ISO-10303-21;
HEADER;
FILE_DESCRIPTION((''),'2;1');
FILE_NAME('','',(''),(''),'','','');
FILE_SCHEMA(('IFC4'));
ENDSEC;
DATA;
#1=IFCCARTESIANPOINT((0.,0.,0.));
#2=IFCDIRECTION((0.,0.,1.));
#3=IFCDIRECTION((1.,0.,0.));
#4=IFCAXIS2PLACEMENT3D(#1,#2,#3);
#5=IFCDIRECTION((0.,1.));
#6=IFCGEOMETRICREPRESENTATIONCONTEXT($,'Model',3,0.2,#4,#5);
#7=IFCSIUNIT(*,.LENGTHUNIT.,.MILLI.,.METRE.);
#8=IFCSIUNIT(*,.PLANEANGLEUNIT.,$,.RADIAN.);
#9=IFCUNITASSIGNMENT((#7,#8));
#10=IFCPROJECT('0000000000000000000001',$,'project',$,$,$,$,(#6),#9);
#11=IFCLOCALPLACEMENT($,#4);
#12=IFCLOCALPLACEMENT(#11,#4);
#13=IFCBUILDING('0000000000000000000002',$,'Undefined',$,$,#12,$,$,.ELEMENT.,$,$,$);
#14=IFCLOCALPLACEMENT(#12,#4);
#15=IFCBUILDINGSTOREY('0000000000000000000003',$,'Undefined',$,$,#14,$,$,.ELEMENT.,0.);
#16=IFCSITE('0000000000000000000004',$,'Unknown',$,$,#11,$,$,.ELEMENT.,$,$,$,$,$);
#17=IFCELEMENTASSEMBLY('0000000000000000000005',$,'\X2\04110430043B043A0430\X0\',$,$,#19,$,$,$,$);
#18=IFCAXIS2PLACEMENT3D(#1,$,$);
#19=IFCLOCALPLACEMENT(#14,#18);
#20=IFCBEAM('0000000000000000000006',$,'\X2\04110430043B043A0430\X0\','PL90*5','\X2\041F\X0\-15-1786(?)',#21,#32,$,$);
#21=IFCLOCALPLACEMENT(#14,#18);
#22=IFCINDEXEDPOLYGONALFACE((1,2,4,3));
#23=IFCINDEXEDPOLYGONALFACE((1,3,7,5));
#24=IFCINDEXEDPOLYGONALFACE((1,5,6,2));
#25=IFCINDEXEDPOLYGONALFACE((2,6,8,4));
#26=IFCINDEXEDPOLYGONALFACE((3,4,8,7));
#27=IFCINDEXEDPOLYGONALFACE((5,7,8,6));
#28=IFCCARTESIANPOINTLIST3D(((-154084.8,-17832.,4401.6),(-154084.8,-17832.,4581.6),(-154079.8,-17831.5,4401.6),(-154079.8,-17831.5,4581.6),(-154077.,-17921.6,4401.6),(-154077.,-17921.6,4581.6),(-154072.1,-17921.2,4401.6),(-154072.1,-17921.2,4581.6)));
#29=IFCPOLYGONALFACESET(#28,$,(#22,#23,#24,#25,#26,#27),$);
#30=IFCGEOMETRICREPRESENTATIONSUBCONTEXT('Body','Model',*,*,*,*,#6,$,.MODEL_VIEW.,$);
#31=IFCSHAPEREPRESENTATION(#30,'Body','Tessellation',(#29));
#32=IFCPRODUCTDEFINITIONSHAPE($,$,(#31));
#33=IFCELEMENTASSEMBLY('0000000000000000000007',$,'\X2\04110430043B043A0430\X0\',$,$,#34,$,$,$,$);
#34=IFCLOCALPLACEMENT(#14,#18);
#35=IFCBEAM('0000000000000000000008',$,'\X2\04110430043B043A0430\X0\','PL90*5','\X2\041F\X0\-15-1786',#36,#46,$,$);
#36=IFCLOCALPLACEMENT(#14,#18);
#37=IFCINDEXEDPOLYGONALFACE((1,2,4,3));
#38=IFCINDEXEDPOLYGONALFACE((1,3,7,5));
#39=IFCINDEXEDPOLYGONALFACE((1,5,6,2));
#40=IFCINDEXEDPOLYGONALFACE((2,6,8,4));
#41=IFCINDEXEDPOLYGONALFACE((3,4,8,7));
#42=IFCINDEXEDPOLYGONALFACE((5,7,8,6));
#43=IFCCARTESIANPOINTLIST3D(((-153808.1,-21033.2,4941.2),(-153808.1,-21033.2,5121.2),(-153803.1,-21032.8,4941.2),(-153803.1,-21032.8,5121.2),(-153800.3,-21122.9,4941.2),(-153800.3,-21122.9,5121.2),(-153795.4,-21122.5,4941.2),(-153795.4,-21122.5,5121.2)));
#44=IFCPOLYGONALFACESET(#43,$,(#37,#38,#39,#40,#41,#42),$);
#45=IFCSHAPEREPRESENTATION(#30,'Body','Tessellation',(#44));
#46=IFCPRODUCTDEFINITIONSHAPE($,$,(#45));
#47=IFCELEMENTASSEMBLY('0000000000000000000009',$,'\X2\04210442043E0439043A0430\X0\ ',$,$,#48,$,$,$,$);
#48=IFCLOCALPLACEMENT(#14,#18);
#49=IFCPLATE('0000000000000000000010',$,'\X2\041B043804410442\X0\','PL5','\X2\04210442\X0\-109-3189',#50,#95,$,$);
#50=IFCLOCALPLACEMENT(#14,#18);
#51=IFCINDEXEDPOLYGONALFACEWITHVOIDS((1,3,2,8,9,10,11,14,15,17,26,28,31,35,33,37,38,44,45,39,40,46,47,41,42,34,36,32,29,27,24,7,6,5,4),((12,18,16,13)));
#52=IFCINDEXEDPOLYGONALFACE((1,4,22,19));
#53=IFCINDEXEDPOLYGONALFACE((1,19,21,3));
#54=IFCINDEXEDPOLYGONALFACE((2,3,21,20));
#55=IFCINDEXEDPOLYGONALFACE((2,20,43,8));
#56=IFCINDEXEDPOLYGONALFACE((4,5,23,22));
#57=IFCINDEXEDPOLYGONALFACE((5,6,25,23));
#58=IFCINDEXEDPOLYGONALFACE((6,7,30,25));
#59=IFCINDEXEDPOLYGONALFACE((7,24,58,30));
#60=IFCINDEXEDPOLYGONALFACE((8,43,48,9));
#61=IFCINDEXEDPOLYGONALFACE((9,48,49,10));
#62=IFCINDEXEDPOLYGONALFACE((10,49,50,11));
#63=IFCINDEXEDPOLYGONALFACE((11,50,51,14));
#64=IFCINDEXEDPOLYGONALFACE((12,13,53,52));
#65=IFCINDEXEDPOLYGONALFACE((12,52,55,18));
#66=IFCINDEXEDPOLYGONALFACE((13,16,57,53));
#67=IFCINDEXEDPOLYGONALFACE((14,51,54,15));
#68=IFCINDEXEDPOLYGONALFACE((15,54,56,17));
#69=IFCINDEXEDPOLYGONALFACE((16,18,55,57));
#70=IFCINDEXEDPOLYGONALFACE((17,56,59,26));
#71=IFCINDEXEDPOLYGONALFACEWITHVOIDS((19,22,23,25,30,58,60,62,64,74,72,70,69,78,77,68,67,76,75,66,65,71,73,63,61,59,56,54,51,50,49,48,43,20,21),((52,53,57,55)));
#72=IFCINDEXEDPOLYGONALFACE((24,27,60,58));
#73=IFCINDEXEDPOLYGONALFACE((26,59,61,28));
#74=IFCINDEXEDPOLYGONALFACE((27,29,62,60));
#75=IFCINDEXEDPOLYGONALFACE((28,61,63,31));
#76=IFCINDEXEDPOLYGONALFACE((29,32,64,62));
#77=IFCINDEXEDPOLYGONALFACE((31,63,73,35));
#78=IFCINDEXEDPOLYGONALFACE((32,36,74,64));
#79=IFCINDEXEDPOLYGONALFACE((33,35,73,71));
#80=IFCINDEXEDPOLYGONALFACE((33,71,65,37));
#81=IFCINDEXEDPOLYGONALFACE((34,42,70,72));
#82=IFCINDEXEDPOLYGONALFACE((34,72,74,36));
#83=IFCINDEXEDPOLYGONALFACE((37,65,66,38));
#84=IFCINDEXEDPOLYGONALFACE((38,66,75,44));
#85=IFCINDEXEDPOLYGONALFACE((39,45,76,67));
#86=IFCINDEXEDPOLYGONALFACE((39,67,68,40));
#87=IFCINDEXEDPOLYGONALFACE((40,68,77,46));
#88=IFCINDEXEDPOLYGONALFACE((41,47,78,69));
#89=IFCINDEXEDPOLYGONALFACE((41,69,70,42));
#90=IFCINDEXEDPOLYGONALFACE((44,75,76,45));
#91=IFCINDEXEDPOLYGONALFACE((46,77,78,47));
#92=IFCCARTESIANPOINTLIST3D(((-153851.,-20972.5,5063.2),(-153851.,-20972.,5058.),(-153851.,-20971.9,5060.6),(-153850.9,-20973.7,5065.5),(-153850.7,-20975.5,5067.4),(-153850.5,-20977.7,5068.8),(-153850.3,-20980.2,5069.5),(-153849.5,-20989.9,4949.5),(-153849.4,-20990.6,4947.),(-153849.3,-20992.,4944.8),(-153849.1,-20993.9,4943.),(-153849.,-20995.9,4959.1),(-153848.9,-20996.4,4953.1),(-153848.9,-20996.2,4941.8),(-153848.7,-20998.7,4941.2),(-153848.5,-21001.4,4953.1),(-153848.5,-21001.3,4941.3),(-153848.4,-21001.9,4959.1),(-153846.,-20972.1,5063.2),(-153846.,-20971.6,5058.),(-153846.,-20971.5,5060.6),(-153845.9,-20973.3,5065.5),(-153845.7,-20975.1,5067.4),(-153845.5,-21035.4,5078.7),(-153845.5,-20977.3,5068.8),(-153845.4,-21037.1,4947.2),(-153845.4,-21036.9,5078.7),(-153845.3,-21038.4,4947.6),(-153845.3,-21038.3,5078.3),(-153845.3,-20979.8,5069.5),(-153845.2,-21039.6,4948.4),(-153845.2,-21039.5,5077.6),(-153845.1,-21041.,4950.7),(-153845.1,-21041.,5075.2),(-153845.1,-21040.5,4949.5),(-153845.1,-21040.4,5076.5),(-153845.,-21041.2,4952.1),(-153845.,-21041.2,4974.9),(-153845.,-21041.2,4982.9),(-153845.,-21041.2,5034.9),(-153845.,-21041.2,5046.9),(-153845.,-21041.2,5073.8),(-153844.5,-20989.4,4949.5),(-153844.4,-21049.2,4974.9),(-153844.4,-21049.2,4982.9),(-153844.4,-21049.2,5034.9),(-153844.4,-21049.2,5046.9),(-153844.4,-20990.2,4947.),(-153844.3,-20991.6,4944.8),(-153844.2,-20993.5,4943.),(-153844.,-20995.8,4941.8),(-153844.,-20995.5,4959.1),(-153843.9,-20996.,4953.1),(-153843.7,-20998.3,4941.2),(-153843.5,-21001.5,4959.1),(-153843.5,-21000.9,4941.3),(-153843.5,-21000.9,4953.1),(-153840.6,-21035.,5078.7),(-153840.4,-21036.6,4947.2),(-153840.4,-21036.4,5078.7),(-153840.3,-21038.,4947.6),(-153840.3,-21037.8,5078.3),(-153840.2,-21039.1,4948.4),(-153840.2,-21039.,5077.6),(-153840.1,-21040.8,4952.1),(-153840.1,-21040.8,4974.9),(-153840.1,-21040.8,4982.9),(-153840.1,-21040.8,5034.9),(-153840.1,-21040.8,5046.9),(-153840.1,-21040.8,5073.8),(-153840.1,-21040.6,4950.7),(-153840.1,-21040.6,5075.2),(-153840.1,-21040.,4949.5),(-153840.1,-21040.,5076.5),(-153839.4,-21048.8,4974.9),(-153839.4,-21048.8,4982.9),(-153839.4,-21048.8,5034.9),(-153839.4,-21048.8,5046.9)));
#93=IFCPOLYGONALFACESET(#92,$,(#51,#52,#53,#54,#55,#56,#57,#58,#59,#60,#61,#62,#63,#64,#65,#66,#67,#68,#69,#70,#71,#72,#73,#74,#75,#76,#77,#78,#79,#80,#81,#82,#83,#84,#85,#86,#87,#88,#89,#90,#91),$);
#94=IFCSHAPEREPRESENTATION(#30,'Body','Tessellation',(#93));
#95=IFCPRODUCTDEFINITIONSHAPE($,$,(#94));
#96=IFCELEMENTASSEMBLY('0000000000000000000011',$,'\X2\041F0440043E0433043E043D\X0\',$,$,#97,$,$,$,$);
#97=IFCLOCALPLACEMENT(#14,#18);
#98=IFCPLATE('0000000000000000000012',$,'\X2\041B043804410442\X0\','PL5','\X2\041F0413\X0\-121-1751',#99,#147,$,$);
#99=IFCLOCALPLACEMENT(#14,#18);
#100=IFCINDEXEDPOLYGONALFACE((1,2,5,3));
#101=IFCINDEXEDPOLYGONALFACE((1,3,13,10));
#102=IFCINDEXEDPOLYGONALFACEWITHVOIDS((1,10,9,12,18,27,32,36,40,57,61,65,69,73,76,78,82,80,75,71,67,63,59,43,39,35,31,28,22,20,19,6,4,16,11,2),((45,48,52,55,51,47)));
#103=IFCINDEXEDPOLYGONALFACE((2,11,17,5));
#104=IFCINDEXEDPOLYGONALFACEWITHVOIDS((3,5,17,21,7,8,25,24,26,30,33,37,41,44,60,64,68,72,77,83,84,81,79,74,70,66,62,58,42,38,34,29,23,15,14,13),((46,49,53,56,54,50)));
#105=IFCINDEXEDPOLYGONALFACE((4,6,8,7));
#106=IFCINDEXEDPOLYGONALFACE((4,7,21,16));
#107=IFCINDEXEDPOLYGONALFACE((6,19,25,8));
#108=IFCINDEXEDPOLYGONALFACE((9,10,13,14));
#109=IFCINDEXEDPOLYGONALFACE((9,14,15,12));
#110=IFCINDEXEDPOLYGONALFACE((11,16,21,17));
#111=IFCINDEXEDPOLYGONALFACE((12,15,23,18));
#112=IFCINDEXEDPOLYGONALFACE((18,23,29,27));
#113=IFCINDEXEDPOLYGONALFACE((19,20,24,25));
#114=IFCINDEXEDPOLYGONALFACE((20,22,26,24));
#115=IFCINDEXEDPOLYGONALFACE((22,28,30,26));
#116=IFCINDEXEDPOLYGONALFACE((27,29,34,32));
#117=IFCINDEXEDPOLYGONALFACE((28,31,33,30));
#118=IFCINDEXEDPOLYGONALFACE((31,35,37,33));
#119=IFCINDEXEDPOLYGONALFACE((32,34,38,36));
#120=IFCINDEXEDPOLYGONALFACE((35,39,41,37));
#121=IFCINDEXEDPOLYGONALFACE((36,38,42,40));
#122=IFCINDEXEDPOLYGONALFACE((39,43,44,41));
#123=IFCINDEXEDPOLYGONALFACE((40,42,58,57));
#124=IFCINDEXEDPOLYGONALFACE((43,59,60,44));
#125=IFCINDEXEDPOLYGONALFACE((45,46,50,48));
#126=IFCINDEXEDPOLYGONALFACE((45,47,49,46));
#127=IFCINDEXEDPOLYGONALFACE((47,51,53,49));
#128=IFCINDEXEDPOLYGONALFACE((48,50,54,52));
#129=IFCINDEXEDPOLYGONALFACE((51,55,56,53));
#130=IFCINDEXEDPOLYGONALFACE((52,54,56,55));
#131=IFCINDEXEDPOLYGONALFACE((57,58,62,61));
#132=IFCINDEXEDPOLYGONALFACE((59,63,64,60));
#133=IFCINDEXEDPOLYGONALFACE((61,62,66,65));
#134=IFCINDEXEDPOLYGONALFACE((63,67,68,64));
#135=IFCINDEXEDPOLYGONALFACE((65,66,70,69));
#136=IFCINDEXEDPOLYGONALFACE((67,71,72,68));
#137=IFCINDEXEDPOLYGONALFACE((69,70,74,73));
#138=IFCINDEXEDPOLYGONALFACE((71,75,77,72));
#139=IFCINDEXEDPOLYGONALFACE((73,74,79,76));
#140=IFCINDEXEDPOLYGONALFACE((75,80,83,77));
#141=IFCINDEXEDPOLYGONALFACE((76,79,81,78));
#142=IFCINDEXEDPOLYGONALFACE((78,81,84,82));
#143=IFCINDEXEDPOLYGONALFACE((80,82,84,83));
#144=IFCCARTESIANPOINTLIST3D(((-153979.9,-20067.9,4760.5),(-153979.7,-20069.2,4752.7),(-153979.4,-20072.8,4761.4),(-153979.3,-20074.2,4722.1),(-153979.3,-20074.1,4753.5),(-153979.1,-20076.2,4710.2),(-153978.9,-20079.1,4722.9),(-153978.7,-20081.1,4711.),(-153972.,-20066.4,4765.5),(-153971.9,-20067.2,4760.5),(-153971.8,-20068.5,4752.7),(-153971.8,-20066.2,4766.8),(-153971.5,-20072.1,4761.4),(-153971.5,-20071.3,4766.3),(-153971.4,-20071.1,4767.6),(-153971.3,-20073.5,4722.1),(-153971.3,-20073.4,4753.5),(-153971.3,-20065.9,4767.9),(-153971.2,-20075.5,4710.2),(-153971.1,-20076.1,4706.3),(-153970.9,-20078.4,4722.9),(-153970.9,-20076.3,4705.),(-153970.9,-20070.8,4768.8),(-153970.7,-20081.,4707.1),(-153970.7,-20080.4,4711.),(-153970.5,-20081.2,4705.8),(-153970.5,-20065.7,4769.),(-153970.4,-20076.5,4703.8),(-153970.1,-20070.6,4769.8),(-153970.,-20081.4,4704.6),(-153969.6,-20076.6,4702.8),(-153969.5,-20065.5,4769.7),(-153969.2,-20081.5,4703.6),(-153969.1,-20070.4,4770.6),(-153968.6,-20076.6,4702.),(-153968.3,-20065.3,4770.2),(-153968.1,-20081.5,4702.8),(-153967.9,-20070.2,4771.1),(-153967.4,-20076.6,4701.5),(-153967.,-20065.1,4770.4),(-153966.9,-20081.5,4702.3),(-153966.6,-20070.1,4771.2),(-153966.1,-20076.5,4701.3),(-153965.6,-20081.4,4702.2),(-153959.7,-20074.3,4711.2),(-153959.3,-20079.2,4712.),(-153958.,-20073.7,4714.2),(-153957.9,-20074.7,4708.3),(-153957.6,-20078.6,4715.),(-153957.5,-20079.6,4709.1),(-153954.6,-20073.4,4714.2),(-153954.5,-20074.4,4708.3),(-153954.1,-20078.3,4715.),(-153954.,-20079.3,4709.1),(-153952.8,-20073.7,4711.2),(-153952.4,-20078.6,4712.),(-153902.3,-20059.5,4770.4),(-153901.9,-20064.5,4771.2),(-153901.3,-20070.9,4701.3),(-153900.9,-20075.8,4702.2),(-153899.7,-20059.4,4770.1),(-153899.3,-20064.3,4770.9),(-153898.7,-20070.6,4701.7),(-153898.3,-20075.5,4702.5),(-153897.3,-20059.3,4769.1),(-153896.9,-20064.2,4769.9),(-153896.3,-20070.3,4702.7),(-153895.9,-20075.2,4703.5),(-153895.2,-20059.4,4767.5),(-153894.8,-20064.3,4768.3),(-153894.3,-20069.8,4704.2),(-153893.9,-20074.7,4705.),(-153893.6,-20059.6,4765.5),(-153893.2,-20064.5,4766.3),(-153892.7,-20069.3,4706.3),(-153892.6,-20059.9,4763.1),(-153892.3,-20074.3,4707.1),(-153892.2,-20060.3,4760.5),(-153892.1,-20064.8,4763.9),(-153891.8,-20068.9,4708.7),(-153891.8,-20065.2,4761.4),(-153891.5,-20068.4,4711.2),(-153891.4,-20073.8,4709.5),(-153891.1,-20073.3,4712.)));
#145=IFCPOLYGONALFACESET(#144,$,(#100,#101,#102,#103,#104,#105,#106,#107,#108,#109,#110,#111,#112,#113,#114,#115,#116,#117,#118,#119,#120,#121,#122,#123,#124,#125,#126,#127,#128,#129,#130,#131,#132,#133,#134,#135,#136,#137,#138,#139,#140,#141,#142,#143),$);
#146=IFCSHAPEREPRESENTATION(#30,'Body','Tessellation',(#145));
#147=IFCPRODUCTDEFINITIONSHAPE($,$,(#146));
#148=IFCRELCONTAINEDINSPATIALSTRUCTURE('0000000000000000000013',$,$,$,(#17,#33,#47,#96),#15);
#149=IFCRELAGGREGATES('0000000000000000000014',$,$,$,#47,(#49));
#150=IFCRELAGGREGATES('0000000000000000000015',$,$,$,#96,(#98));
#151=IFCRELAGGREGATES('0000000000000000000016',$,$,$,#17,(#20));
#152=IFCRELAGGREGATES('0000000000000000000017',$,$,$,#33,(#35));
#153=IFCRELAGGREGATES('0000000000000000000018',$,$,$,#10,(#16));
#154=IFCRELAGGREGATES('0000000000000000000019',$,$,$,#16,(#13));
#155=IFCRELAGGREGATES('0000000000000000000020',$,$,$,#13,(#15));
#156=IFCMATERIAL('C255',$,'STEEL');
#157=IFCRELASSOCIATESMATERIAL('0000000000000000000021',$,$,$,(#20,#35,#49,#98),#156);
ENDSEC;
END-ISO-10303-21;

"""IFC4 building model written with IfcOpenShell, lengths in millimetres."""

from ifc_helpers import new_model, si_unit, direction, frame, origin_with_axes, place, context, subcontext, project, spatial, line, arc, indexed_curve, outline, extrude, material, element, aggregate, save


model = new_model("IFC4")

# Units and contexts
model_context = context("Model", 3, precision=0.2, world=origin_with_axes(), true_north=direction((0.0, 1.0)))
body_context = subcontext(model_context, "Body", "Model", "MODEL_VIEW")
ifc_project = project(units=[si_unit("LENGTHUNIT", "METRE", prefix="MILLI"), si_unit("PLANEANGLEUNIT", "RADIAN")], contexts=[model_context])

# Site, building, storey
site_placement = place(None, origin_with_axes())
site = spatial("IfcSite", under=ifc_project, at=site_placement, Name="Unknown", CompositionType="ELEMENT")
building_placement = place(site_placement, origin_with_axes())
building = spatial("IfcBuilding", under=site, at=building_placement, Name="Undefined", CompositionType="ELEMENT")
storey_placement = place(building_placement, origin_with_axes())
storey = spatial("IfcBuildingStorey", under=building, at=storey_placement, Name="Undefined", CompositionType="ELEMENT", Elevation=0.0)

# Element assemblies, beams
assembly_1_placement = place(storey_placement, frame((-154078.4, -17876.6, 4581.6), z_axis=(0.996285, 0.086114, 0.0), x_axis=(0.0, 0.0, -1.0)))
assembly_1 = element("IfcElementAssembly", 1, at=assembly_1_placement, inside=storey, Name="Балка")
ifc_material_1 = material(Name="C255", Category="STEEL")
beam_1_placement = place(assembly_1_placement, origin_with_axes())
beam_1 = element("IfcBeam", 2, at=beam_1_placement, material=ifc_material_1, Name="Балка", Description="PL90*5", ObjectType="П-15-1786(?)", context=body_context, shape_type="SolidModel", body=[
    extrude(outline(indexed_curve([(-2.5, -45.0), (2.5, -45.0), (2.5, 45.0), (-2.5, 45.0)], segments=[line(1, 2, 3, 4, 1)])), frame((0.0, 0.0, 0.0), z_axis=(-1.0, 0.0, 0.0), x_axis=(0.0, 0.0, 1.0)), (0.0, 0.0, -1.0), 180.0),
])
assembly_2_placement = place(storey_placement, frame((-153801.7, -21077.8, 5121.2), z_axis=(0.996285, 0.086114, 0.0), x_axis=(0.0, 0.0, -1.0)))
assembly_2 = element("IfcElementAssembly", 3, at=assembly_2_placement, inside=storey, Name="Балка")
beam_2_placement = place(assembly_2_placement, origin_with_axes())
beam_2 = element("IfcBeam", 4, at=beam_2_placement, material=ifc_material_1, Name="Балка", Description="PL90*5", ObjectType="П-15-1786", context=body_context, shape_type="SolidModel", body=[
    extrude(outline(indexed_curve([(-2.5, -45.0), (2.5, -45.0), (2.5, 45.0), (-2.5, 45.0)], segments=[line(1, 2, 3, 4, 1)])), frame((0.0, 0.0, 0.0), z_axis=(-1.0, 0.0, 0.0), x_axis=(0.0, 0.0, 1.0)), (0.0, 0.0, -1.0), 180.0),
])

# Element assemblies, plates, voiding features
assembly_3_placement = place(storey_placement, frame((-153844.1, -21081.5, 1298.5), z_axis=(-0.086114, 0.996285, 0.0), x_axis=(0.0, 0.0, 1.0)))
assembly_3 = element("IfcElementAssembly", 5, at=assembly_3_placement, inside=storey, Name="Стойка ")
plate_1_placement = place(assembly_3_placement, frame((3641.1, 5.0, 90.1), z_axis=(-0.000024, 1.0, 0.0), x_axis=(0.986646, 0.000024, 0.162881)))
plate_1 = element("IfcPlate", 6, at=plate_1_placement, material=ifc_material_1, Name="Лист", Description="PL5", ObjectType="Ст-109-3189", context=body_context, shape_type="SolidModel", body=[
    extrude(outline(indexed_curve([(0.0, 10.0), (2.9, 2.9), (10.0, 0.0), (120.0, 0.0), (127.1, 2.9), (130.0, 10.0), (130.0, 66.2), (128.2, 70.0), (124.2, 71.1), (97.7, 66.7), (96.4, 74.6), (84.5, 72.7), (85.8, 64.8), (34.5, 56.3), (33.2, 64.2), (25.3, 62.9), (26.6, 55.0), (4.2, 51.3), (1.2, 49.6), (0.0, 46.4)], segments=[arc(1, 2, 3), line(3, 4), arc(4, 5, 6), line(6, 7), arc(7, 8, 9), line(9, 10, 11, 12, 13, 14, 15, 16, 17, 18), arc(18, 19, 20), line(20, 1)])), frame((0.0, 0.0, 2.5), z_axis=(0.0, 0.0, 1.0), x_axis=(1.0, 0.0, 0.0)), (0.0, 0.0, -1.0), 5.0),
])
voiding_feature_1_placement = place(plate_1_placement, frame((15.0, 10.0, 10.0), z_axis=(0.165862, -0.986149, 0.0), x_axis=(0.0, 0.0, -1.0)))
element("IfcVoidingFeature", 7, at=voiding_feature_1_placement, cuts=plate_1, Name="Балка", ObjectType="(?)", PredefinedType="HOLE", context=body_context, shape_type="SolidModel", body=[
    extrude(outline(indexed_curve([(2.5, -3.0), (3.0, 3.0), (-3.0, 3.0), (-2.5, -3.0)], segments=[line(1, 2, 3, 4, 1)])), frame((0.0, 0.0, 0.0), z_axis=(-1.0, 0.0, 0.0), x_axis=(0.0, 0.0, 1.0)), (0.0, 0.0, -1.0), 20.0),
])
assembly_4_placement = place(storey_placement, frame((-154011.0, -20079.0, 3798.5), z_axis=(0.086114, -0.996285, 0.0), x_axis=(0.0, 0.0, 1.0)))
assembly_4 = element("IfcElementAssembly", 8, at=assembly_4_placement, inside=storey, Name="Прогон")
plate_2_placement = place(assembly_4_placement, frame((972.3, -120.0, -7.5), z_axis=(-0.162881, -0.000054, -0.986646), x_axis=(-0.986646, 0.000078, 0.162881)))
plate_2 = element("IfcPlate", 9, at=plate_2_placement, material=ifc_material_1, Name="Лист", Description="PL5", ObjectType="ПГ-121-1751", context=body_context, shape_type="SolidModel", body=[
    extrude(outline(indexed_curve([(0.0, 10.0), (2.9, 2.9), (10.0, 0.0), (60.0, 0.0), (67.1, 2.9), (70.0, 10.0), (70.0, 75.0), (68.5, 78.5), (65.0, 80.0), (61.0, 80.0), (61.0, 88.0), (49.0, 88.0), (49.0, 80.0), (18.0, 80.0), (18.0, 88.0), (10.0, 88.0), (10.0, 80.0), (5.0, 80.0), (1.5, 78.5), (0.0, 75.0)], segments=[arc(1, 2, 3), line(3, 4), arc(4, 5, 6), line(6, 7), arc(7, 8, 9), line(9, 10, 11, 12, 13, 14, 15, 16, 17, 18), arc(18, 19, 20), line(20, 1)])), frame((0.0, 0.0, 2.5), z_axis=(0.0, 0.0, 1.0), x_axis=(1.0, 0.0, 0.0)), (0.0, 0.0, -1.0), 5.0),
])
voiding_feature_2_placement = place(plate_2_placement, frame((60.0, 65.0, 6.0), z_axis=(-0.000054, -1.0, 0.000034), x_axis=(0.0, -0.000034, -1.0)))
element("IfcVoidingFeature", 10, at=voiding_feature_2_placement, cuts=plate_2, Name="Балка", ObjectType="(?)", PredefinedType="HOLE", context=body_context, shape_type="SolidModel", body=[
    extrude(outline(indexed_curve([(1.7, -3.0), (3.5, 0.0), (1.7, 3.0), (-1.7, 3.0), (-3.5, 0.0), (-1.7, -3.0)], segments=[line(1, 2, 3, 4, 5, 6, 1)])), frame((0.0, 0.0, 0.0), z_axis=(-1.0, 0.0, 0.0), x_axis=(0.0, 0.0, 1.0)), (0.0, 0.0, -1.0), 12.0),
])

aggregate(assembly_3, [plate_1])
aggregate(assembly_4, [plate_2])

aggregate(assembly_1, [beam_1])

aggregate(assembly_2, [beam_2])

save(model, "model.ifc")
